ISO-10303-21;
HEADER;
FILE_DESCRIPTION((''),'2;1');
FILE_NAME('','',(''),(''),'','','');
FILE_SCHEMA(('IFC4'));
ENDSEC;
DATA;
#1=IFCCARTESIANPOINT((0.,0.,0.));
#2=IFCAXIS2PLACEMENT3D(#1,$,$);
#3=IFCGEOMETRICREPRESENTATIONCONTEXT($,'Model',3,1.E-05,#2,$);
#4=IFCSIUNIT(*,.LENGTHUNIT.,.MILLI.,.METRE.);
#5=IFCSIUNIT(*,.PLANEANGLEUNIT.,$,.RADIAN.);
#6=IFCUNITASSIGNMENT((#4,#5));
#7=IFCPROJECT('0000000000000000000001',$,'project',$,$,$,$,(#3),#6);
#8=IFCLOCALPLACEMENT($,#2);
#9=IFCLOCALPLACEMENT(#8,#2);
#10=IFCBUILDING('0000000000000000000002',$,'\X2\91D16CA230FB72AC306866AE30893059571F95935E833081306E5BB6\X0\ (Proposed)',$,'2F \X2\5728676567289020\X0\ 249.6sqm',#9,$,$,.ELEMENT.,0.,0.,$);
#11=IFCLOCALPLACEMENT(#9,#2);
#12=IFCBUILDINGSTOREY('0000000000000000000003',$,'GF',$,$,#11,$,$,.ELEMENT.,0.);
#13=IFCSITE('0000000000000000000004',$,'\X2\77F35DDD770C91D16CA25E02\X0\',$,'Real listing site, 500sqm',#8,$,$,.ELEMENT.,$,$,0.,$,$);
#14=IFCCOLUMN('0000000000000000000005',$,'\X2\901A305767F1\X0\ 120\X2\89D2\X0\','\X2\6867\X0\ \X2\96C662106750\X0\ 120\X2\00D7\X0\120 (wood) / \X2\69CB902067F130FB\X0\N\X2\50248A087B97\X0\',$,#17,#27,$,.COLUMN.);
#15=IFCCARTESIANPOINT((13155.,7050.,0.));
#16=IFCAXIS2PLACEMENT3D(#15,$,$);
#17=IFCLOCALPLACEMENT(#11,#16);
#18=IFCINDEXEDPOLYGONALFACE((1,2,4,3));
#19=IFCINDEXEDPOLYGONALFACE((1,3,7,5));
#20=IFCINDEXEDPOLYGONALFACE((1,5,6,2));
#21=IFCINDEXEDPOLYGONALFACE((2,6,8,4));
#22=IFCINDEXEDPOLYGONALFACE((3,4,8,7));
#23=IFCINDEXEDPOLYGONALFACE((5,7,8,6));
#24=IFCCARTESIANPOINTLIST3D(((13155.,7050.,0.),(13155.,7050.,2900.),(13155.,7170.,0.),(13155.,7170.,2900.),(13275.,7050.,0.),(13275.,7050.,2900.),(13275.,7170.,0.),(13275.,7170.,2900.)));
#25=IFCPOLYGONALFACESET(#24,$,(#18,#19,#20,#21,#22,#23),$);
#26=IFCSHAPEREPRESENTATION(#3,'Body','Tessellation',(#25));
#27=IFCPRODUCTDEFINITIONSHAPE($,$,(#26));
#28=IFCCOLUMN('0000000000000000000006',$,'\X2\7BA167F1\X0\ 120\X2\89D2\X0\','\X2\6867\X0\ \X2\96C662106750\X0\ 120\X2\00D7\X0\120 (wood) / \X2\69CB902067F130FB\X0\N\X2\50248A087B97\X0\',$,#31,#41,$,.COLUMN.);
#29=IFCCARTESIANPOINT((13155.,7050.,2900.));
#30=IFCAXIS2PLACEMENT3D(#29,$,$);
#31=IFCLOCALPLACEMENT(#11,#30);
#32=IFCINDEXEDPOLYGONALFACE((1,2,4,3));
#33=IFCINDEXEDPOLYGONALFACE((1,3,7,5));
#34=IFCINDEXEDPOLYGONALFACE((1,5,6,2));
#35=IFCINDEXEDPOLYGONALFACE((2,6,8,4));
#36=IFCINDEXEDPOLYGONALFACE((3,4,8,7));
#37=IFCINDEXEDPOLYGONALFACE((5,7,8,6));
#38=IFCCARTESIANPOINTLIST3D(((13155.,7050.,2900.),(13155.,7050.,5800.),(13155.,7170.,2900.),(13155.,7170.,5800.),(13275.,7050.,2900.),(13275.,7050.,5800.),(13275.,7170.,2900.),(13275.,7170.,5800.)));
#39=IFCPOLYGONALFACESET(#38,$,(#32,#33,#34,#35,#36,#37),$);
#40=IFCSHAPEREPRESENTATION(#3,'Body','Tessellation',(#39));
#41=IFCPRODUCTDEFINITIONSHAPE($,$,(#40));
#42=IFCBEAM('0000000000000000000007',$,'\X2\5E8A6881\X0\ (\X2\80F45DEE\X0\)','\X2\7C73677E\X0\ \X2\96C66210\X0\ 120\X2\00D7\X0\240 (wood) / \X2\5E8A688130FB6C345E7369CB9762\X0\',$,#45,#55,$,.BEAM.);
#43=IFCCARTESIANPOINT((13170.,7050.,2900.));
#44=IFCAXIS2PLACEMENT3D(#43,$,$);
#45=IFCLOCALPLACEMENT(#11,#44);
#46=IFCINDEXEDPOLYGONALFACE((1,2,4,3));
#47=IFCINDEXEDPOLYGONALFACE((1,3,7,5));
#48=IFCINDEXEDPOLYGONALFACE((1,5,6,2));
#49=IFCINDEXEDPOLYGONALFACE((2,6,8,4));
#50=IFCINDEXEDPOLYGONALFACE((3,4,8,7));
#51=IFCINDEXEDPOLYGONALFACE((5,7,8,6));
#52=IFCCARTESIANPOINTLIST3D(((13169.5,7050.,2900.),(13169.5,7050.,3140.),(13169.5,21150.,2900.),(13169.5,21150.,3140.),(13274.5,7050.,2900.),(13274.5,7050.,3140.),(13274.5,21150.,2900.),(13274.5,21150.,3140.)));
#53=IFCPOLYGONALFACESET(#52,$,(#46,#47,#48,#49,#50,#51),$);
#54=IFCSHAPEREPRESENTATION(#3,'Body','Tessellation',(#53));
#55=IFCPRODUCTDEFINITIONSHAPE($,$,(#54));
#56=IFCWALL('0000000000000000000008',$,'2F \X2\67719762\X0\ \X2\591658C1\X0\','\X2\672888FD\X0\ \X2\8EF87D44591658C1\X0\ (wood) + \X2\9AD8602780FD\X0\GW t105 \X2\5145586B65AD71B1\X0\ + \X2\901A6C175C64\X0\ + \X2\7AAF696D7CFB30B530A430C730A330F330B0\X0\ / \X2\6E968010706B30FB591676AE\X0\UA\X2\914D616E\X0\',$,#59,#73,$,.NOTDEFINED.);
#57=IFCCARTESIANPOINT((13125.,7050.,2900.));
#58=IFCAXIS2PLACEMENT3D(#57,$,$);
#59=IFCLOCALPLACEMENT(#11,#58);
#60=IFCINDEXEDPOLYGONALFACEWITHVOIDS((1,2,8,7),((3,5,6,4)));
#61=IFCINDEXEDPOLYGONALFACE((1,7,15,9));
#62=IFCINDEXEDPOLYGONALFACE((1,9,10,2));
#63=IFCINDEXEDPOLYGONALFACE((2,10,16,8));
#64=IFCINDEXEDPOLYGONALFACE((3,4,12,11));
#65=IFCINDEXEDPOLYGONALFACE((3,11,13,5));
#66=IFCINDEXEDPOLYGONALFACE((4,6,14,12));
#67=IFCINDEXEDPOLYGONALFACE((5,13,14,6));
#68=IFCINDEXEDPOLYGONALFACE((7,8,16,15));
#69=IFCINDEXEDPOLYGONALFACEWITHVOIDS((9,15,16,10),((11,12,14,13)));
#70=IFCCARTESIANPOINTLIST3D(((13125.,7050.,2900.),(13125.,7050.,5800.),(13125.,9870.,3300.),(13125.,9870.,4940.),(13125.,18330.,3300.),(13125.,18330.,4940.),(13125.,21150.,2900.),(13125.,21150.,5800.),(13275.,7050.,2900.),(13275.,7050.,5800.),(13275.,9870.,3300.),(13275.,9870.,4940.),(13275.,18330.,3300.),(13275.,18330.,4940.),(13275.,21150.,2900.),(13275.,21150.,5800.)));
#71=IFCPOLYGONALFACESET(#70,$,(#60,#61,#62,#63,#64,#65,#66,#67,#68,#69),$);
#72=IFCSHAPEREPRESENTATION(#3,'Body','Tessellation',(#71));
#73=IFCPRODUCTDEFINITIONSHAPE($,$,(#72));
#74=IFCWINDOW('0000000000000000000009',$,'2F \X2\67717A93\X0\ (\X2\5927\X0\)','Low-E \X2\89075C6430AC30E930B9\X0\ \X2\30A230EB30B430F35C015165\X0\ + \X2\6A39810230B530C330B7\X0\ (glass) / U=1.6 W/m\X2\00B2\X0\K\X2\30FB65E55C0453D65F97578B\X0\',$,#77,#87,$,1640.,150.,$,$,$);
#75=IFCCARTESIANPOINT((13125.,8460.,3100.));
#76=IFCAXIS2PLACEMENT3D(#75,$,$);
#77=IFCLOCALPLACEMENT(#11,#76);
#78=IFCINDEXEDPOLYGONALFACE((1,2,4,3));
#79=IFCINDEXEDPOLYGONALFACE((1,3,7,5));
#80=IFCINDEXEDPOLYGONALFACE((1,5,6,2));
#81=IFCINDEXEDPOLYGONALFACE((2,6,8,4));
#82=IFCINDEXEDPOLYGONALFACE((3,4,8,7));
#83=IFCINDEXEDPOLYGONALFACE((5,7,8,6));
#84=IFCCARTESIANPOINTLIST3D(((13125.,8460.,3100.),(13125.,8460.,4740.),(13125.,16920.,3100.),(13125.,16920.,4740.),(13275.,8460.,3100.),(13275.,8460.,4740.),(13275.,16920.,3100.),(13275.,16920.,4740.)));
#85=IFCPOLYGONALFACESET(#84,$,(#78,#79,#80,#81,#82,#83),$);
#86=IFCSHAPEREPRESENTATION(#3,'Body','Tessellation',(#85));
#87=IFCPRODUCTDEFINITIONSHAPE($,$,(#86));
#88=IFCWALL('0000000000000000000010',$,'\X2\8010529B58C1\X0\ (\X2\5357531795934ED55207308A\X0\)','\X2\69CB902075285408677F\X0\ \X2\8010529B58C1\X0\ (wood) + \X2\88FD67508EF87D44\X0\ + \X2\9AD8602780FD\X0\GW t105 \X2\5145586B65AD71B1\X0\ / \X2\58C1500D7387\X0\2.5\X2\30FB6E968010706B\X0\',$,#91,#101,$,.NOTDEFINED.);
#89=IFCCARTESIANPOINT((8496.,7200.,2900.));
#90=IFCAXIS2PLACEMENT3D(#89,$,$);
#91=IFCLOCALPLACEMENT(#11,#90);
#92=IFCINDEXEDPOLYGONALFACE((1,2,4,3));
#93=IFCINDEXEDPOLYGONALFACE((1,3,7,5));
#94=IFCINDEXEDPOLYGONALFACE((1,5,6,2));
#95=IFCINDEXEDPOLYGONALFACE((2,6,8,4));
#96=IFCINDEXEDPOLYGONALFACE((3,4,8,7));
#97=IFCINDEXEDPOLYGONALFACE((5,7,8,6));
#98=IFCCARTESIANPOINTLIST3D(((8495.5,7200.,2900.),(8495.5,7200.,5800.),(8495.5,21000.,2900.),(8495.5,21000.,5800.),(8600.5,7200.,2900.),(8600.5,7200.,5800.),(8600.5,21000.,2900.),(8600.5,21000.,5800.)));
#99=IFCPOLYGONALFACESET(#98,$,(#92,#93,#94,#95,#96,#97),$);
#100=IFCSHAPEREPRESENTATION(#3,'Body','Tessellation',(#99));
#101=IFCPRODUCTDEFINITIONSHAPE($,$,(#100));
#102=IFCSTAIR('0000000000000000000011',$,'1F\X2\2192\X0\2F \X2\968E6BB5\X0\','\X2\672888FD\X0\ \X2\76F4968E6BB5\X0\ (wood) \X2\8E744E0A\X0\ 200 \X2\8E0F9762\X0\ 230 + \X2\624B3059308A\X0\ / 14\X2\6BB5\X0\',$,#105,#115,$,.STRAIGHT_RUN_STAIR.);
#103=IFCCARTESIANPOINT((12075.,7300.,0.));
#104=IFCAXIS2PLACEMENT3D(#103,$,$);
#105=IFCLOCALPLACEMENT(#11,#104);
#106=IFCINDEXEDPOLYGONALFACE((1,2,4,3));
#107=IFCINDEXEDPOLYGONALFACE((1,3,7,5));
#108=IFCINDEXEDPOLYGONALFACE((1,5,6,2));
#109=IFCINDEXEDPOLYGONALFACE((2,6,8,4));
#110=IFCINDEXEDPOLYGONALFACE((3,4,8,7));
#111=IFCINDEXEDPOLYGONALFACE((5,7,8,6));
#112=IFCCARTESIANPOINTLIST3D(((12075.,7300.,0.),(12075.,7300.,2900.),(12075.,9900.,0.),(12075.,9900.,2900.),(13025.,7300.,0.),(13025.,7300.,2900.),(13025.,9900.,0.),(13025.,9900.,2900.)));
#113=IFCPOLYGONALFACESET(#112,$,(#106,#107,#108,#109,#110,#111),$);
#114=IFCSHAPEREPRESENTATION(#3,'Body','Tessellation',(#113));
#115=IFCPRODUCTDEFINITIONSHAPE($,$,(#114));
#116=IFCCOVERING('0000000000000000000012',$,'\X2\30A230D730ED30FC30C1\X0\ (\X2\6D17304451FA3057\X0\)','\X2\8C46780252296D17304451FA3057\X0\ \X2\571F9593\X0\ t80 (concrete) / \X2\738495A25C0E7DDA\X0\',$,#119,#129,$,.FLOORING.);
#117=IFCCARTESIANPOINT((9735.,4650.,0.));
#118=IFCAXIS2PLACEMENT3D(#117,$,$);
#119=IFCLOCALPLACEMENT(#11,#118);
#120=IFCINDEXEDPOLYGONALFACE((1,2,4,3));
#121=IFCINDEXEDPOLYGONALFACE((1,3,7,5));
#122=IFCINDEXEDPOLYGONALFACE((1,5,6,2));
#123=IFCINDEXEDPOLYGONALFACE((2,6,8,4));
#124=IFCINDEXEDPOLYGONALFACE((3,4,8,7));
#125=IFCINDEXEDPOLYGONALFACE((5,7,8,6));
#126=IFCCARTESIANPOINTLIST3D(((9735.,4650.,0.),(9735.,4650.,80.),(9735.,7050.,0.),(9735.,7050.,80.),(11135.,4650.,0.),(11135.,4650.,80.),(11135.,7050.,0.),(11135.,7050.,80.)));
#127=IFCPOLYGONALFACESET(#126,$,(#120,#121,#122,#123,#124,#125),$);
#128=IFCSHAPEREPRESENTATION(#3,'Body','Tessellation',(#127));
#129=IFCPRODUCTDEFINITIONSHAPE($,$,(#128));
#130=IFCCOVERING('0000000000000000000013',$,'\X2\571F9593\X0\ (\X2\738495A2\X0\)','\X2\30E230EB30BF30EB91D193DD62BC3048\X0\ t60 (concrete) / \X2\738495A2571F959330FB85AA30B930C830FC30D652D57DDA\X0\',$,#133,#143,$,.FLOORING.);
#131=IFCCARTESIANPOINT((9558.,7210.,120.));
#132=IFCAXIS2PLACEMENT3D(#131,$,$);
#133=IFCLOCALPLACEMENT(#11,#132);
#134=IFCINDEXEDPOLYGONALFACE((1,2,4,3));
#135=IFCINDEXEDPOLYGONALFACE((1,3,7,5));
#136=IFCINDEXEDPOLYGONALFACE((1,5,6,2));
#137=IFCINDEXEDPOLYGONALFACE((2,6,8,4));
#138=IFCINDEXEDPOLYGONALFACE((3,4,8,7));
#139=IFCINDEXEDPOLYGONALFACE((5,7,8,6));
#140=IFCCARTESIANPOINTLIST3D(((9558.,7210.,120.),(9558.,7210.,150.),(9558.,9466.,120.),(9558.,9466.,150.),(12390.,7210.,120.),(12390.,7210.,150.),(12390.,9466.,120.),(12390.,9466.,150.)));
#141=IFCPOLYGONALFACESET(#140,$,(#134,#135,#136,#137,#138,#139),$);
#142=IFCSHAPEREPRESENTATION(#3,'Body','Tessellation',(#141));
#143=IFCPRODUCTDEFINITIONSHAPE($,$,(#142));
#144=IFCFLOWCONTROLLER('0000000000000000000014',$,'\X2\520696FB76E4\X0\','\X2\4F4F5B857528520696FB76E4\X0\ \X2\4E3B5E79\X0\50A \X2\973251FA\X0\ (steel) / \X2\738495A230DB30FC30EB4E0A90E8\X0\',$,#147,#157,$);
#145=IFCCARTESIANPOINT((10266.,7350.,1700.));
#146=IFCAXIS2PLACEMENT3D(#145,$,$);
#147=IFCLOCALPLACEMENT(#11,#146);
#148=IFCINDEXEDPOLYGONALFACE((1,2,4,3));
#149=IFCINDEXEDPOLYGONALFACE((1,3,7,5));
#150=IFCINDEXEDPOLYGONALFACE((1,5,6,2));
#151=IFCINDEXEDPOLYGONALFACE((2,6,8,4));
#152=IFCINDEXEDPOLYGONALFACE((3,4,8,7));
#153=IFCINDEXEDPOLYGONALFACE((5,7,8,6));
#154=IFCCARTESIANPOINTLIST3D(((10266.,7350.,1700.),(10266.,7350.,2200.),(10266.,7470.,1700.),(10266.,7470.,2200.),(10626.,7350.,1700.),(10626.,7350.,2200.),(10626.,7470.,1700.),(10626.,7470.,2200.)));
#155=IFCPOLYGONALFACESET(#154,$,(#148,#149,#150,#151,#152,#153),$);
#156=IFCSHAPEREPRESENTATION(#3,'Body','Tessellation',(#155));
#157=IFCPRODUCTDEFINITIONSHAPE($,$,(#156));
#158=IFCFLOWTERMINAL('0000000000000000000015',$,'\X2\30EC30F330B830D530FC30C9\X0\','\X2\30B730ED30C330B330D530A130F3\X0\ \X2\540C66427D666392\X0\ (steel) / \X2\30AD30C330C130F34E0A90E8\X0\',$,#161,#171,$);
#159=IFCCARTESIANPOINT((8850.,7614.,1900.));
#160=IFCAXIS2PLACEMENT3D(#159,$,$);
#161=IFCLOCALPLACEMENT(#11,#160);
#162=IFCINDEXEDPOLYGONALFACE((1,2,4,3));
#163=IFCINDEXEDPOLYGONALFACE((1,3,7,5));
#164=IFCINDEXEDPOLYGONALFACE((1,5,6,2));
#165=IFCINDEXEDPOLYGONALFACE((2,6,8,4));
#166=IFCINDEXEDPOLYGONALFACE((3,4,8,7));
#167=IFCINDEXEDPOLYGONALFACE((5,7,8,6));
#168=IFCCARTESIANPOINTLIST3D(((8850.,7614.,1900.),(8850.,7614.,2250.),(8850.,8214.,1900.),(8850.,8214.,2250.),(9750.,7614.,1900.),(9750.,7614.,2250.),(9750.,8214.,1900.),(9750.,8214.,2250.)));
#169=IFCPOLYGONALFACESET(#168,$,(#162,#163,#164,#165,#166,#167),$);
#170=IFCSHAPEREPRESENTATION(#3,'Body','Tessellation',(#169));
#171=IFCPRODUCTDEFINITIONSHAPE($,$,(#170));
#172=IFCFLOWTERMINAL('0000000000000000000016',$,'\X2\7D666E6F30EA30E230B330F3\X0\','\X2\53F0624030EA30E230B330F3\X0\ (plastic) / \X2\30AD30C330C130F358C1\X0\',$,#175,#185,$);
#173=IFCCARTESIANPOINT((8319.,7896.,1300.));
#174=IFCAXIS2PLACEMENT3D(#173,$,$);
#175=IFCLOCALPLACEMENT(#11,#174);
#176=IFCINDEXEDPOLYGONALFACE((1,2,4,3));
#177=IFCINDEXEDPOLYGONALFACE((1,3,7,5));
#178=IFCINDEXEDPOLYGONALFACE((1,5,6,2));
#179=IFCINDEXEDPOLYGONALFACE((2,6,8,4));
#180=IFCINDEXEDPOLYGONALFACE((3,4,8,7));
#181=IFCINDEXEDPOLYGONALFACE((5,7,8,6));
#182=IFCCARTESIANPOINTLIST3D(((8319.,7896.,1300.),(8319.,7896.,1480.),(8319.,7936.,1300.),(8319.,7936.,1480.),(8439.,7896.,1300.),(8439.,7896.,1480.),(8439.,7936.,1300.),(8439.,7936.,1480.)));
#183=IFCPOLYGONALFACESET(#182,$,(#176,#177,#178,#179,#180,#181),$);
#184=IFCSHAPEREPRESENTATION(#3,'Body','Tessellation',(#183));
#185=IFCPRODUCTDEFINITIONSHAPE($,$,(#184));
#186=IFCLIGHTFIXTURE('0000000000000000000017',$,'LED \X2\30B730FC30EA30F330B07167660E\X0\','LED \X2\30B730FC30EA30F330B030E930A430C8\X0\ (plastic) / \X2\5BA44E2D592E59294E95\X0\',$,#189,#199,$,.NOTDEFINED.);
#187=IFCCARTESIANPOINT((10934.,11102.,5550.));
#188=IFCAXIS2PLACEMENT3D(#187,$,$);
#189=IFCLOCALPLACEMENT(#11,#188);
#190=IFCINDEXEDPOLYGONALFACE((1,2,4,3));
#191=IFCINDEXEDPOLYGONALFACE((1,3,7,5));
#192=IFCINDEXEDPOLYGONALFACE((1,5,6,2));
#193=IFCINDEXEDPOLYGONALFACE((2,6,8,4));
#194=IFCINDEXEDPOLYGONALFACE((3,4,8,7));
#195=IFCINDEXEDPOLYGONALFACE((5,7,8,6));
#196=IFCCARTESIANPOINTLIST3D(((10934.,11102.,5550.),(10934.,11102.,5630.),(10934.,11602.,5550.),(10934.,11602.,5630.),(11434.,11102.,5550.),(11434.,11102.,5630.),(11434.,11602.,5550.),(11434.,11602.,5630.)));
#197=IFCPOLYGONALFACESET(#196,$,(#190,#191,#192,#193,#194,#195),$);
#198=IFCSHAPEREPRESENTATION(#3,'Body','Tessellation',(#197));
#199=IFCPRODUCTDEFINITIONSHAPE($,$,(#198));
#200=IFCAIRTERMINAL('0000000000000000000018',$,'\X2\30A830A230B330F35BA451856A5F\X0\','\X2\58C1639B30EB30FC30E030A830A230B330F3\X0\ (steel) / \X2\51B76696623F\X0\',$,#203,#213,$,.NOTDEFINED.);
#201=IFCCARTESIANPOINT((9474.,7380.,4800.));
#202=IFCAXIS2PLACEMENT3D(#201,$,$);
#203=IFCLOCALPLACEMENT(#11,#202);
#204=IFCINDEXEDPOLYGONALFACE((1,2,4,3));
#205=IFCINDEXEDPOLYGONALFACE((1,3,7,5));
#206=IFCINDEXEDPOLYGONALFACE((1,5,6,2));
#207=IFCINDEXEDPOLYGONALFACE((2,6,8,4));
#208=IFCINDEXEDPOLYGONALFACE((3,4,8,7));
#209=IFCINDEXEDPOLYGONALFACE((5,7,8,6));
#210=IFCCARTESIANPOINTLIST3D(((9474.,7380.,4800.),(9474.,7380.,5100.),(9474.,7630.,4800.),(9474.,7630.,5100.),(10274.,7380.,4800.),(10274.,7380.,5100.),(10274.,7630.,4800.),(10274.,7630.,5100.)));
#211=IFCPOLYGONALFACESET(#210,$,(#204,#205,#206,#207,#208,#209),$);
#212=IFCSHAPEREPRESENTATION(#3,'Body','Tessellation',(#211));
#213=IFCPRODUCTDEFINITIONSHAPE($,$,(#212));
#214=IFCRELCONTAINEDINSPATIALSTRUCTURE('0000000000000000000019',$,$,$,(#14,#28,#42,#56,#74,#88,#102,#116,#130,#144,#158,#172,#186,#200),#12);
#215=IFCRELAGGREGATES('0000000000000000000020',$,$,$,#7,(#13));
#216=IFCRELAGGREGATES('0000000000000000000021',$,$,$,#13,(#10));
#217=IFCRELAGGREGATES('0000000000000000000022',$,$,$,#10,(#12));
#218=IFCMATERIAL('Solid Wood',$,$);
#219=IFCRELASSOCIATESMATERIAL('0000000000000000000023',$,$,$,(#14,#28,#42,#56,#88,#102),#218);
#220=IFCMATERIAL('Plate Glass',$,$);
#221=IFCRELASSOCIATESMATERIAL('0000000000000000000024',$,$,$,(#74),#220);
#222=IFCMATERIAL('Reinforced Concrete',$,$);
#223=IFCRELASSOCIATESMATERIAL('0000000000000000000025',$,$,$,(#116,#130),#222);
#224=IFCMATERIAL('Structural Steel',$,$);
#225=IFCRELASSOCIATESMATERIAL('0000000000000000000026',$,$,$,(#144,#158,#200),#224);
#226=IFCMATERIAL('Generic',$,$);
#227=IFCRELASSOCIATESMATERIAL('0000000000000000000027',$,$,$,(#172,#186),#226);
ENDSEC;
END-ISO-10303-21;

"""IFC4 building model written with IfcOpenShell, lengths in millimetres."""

from ifc_helpers import new_model, si_unit, frame, frame_2d, origin, place, context, project, spatial, rectangle, extrude, material, element, fill, save


model = new_model("IFC4")

# Units and contexts
model_context = context("Model", 3, precision=1e-05, world=origin())
ifc_project = project(units=[si_unit("LENGTHUNIT", "METRE", prefix="MILLI"), si_unit("PLANEANGLEUNIT", "RADIAN")], contexts=[model_context])

# Site, building, storey
site_placement = place(None, origin())
site = spatial("IfcSite", under=ifc_project, at=site_placement, Name="石川県金沢市", ObjectType="Real listing site, 500sqm", CompositionType="ELEMENT", RefElevation=0.0)
building_placement = place(site_placement, origin())
building = spatial("IfcBuilding", under=site, at=building_placement, Name="金沢・犬と暮らす土間広めの家 (Proposed)", ObjectType="2F 在来木造 249.6sqm", CompositionType="ELEMENT", ElevationOfRefHeight=0.0, ElevationOfTerrain=0.0)
storey_placement = place(building_placement, origin())
storey = spatial("IfcBuildingStorey", under=building, at=storey_placement, Name="GF", CompositionType="ELEMENT", Elevation=0.0)

# Columns
ifc_material_1 = material(Name="Solid Wood")
column_1_placement = place(storey_placement, frame((13155.0, 7050.0, 0.0)))
element("IfcColumn", 1, at=column_1_placement, inside=storey, material=ifc_material_1, Name="通し柱 120角", Description="桧 集成材 120×120 (wood) / 構造柱・N値計算", PredefinedType="COLUMN", context=model_context, shape_type="SweptSolid", body=[
    extrude(rectangle(XDim=120.0, YDim=120.0, at=frame_2d((60.0, 60.0))), frame((13155.0, 7050.0, 0.0)), (0.0, 0.0, 1.0), 2900.0),
])
column_2_placement = place(storey_placement, frame((13155.0, 7050.0, 2900.0)))
element("IfcColumn", 2, at=column_2_placement, inside=storey, material=ifc_material_1, Name="管柱 120角", Description="桧 集成材 120×120 (wood) / 構造柱・N値計算", PredefinedType="COLUMN", context=model_context, shape_type="SweptSolid", body=[
    extrude(rectangle(XDim=120.0, YDim=120.0, at=frame_2d((60.0, 60.0))), frame((13155.0, 7050.0, 2900.0)), (0.0, 0.0, 1.0), 2900.0),
])

# Beam
beam_1_placement = place(storey_placement, frame((13170.0, 7050.0, 2900.0)))
element("IfcBeam", 3, at=beam_1_placement, inside=storey, material=ifc_material_1, Name="床梁 (胴差)", Description="米松 集成 120×240 (wood) / 床梁・水平構面", PredefinedType="BEAM", context=model_context, shape_type="SweptSolid", body=[
    extrude(rectangle(XDim=105.0, YDim=14100.0, at=frame_2d((52.0, 7050.0))), frame((13170.0, 7050.0, 2900.0)), (0.0, 0.0, 1.0), 240.0),
])

# Shared definitions
ifc_material_2 = material(Name="Plate Glass")

# Wall, opening, window
wall_1_placement = place(storey_placement, frame((13125.0, 7050.0, 2900.0)))
wall_1 = element("IfcWall", 4, at=wall_1_placement, inside=storey, material=ifc_material_1, Name="2F 東面 外壁", Description="木製 軸組外壁 (wood) + 高性能GW t105 充填断熱 + 通気層 + 窯業系サイディング / 準耐火・外皮UA配慮", PredefinedType="NOTDEFINED", context=model_context, shape_type="SweptSolid", body=[
    extrude(rectangle(XDim=150.0, YDim=14100.0, at=frame_2d((75.0, 7050.0))), frame((13125.0, 7050.0, 2900.0)), (0.0, 0.0, 1.0), 2900.0),
])
opening_1_placement = place(storey_placement, frame((13125.0, 8460.0, 3100.0)))
opening_1 = element("IfcOpeningElement", 5, at=opening_1_placement, cuts=wall_1, PredefinedType="NOTDEFINED", context=model_context, shape_type="SweptSolid", body=[
    extrude(rectangle(XDim=150.0, YDim=8460.0, at=frame_2d((75.0, 4230.0))), frame((13125.0, 8460.0, 3100.0)), (0.0, 0.0, 1.0), 1640.0),
])
window_1_placement = place(storey_placement, frame((13125.0, 8460.0, 3100.0)))
window_1 = element("IfcWindow", 6, at=window_1_placement, inside=storey, material=ifc_material_2, Name="2F 東窓 (大)", Description="Low-E 複層ガラス アルゴン封入 + 樹脂サッシ (glass) / U=1.6 W/m²K・日射取得型", OverallHeight=1640.0, OverallWidth=150.0, context=model_context, shape_type="SweptSolid", body=[
    extrude(rectangle(XDim=150.0, YDim=8460.0, at=frame_2d((75.0, 4230.0))), frame((13125.0, 8460.0, 3100.0)), (0.0, 0.0, 1.0), 1640.0),
])
fill(opening_1, window_1)

# Wall
wall_2_placement = place(storey_placement, frame((8496.0, 7200.0, 2900.0)))
element("IfcWall", 7, at=wall_2_placement, inside=storey, material=ifc_material_1, Name="耐力壁 (南北間仕切り)", Description="構造用合板 耐力壁 (wood) + 製材軸組 + 高性能GW t105 充填断熱 / 壁倍率2.5・準耐火", PredefinedType="NOTDEFINED", context=model_context, shape_type="SweptSolid", body=[
    extrude(rectangle(XDim=105.0, YDim=13800.0, at=frame_2d((52.0, 6900.0))), frame((8496.0, 7200.0, 2900.0)), (0.0, 0.0, 1.0), 2900.0),
])

# Stair
stair_placement = place(storey_placement, frame((12075.0, 7300.0, 0.0)))
element("IfcStair", 8, at=stair_placement, inside=storey, material=ifc_material_1, Name="1F→2F 階段", Description="木製 直階段 (wood) 蹴上 200 踏面 230 + 手すり / 14段", PredefinedType="STRAIGHT_RUN_STAIR", context=model_context, shape_type="SweptSolid", body=[
    extrude(rectangle(XDim=950.0, YDim=2600.0, at=frame_2d((475.0, 1300.0))), frame((12075.0, 7300.0, 0.0)), (0.0, 0.0, 1.0), 2900.0),
])

# Coverings
ifc_material_3 = material(Name="Reinforced Concrete")
covering_1_placement = place(storey_placement, frame((9735.0, 4650.0, 0.0)))
element("IfcCovering", 9, at=covering_1_placement, inside=storey, material=ifc_material_3, Name="アプローチ (洗い出し)", Description="豆砂利洗い出し 土間 t80 (concrete) / 玄関導線", PredefinedType="FLOORING", context=model_context, shape_type="SweptSolid", body=[
    extrude(rectangle(XDim=1400.0, YDim=2400.0, at=frame_2d((700.0, 1200.0))), frame((9735.0, 4650.0, 0.0)), (0.0, 0.0, 1.0), 80.0),
])
covering_2_placement = place(storey_placement, frame((9558.0, 7210.0, 120.0)))
element("IfcCovering", 10, at=covering_2_placement, inside=storey, material=ifc_material_3, Name="土間 (玄関)", Description="モルタル金鏝押え t60 (concrete) / 玄関土間・薪ストーブ動線", PredefinedType="FLOORING", context=model_context, shape_type="SweptSolid", body=[
    extrude(rectangle(XDim=2832.0, YDim=2256.0, at=frame_2d((1416.0, 1128.0))), frame((9558.0, 7210.0, 120.0)), (0.0, 0.0, 1.0), 30.0),
])

# Flow controller
ifc_material_4 = material(Name="Structural Steel")
flow_controller_placement = place(storey_placement, frame((10266.0, 7350.0, 1700.0)))
element("IfcFlowController", 11, at=flow_controller_placement, inside=storey, material=ifc_material_4, Name="分電盤", Description="住宅用分電盤 主幹50A 露出 (steel) / 玄関ホール上部", context=model_context, shape_type="SweptSolid", body=[
    extrude(rectangle(XDim=360.0, YDim=120.0, at=frame_2d((180.0, 60.0))), frame((10266.0, 7350.0, 1700.0)), (0.0, 0.0, 1.0), 500.0),
])

# Flow terminals
flow_terminal_1_placement = place(storey_placement, frame((8850.0, 7614.0, 1900.0)))
element("IfcFlowTerminal", 12, at=flow_terminal_1_placement, inside=storey, material=ifc_material_4, Name="レンジフード", Description="シロッコファン 同時給排 (steel) / キッチン上部", context=model_context, shape_type="SweptSolid", body=[
    extrude(rectangle(XDim=900.0, YDim=600.0, at=frame_2d((450.0, 300.0))), frame((8850.0, 7614.0, 1900.0)), (0.0, 0.0, 1.0), 350.0),
])
ifc_material_5 = material(Name="Generic")
flow_terminal_2_placement = place(storey_placement, frame((8319.0, 7896.0, 1300.0)))
element("IfcFlowTerminal", 13, at=flow_terminal_2_placement, inside=storey, material=ifc_material_5, Name="給湯リモコン", Description="台所リモコン (plastic) / キッチン壁", context=model_context, shape_type="SweptSolid", body=[
    extrude(rectangle(XDim=120.0, YDim=40.0, at=frame_2d((60.0, 20.0))), frame((8319.0, 7896.0, 1300.0)), (0.0, 0.0, 1.0), 180.0),
])

# Light fixture
light_fixture_placement = place(storey_placement, frame((10934.0, 11102.0, 5550.0)))
element("IfcLightFixture", 14, at=light_fixture_placement, inside=storey, material=ifc_material_5, Name="LED シーリング照明", Description="LED シーリングライト (plastic) / 室中央天井", PredefinedType="NOTDEFINED", context=model_context, shape_type="SweptSolid", body=[
    extrude(rectangle(XDim=500.0, YDim=500.0, at=frame_2d((250.0, 250.0))), frame((10934.0, 11102.0, 5550.0)), (0.0, 0.0, 1.0), 80.0),
])

# Air terminal
air_terminal_placement = place(storey_placement, frame((9474.0, 7380.0, 4800.0)))
element("IfcAirTerminal", 15, at=air_terminal_placement, inside=storey, material=ifc_material_4, Name="エアコン室内機", Description="壁掛ルームエアコン (steel) / 冷暖房", PredefinedType="NOTDEFINED", context=model_context, shape_type="SweptSolid", body=[
    extrude(rectangle(XDim=800.0, YDim=250.0, at=frame_2d((400.0, 125.0))), frame((9474.0, 7380.0, 4800.0)), (0.0, 0.0, 1.0), 300.0),
])

save(model, "model.ifc")
